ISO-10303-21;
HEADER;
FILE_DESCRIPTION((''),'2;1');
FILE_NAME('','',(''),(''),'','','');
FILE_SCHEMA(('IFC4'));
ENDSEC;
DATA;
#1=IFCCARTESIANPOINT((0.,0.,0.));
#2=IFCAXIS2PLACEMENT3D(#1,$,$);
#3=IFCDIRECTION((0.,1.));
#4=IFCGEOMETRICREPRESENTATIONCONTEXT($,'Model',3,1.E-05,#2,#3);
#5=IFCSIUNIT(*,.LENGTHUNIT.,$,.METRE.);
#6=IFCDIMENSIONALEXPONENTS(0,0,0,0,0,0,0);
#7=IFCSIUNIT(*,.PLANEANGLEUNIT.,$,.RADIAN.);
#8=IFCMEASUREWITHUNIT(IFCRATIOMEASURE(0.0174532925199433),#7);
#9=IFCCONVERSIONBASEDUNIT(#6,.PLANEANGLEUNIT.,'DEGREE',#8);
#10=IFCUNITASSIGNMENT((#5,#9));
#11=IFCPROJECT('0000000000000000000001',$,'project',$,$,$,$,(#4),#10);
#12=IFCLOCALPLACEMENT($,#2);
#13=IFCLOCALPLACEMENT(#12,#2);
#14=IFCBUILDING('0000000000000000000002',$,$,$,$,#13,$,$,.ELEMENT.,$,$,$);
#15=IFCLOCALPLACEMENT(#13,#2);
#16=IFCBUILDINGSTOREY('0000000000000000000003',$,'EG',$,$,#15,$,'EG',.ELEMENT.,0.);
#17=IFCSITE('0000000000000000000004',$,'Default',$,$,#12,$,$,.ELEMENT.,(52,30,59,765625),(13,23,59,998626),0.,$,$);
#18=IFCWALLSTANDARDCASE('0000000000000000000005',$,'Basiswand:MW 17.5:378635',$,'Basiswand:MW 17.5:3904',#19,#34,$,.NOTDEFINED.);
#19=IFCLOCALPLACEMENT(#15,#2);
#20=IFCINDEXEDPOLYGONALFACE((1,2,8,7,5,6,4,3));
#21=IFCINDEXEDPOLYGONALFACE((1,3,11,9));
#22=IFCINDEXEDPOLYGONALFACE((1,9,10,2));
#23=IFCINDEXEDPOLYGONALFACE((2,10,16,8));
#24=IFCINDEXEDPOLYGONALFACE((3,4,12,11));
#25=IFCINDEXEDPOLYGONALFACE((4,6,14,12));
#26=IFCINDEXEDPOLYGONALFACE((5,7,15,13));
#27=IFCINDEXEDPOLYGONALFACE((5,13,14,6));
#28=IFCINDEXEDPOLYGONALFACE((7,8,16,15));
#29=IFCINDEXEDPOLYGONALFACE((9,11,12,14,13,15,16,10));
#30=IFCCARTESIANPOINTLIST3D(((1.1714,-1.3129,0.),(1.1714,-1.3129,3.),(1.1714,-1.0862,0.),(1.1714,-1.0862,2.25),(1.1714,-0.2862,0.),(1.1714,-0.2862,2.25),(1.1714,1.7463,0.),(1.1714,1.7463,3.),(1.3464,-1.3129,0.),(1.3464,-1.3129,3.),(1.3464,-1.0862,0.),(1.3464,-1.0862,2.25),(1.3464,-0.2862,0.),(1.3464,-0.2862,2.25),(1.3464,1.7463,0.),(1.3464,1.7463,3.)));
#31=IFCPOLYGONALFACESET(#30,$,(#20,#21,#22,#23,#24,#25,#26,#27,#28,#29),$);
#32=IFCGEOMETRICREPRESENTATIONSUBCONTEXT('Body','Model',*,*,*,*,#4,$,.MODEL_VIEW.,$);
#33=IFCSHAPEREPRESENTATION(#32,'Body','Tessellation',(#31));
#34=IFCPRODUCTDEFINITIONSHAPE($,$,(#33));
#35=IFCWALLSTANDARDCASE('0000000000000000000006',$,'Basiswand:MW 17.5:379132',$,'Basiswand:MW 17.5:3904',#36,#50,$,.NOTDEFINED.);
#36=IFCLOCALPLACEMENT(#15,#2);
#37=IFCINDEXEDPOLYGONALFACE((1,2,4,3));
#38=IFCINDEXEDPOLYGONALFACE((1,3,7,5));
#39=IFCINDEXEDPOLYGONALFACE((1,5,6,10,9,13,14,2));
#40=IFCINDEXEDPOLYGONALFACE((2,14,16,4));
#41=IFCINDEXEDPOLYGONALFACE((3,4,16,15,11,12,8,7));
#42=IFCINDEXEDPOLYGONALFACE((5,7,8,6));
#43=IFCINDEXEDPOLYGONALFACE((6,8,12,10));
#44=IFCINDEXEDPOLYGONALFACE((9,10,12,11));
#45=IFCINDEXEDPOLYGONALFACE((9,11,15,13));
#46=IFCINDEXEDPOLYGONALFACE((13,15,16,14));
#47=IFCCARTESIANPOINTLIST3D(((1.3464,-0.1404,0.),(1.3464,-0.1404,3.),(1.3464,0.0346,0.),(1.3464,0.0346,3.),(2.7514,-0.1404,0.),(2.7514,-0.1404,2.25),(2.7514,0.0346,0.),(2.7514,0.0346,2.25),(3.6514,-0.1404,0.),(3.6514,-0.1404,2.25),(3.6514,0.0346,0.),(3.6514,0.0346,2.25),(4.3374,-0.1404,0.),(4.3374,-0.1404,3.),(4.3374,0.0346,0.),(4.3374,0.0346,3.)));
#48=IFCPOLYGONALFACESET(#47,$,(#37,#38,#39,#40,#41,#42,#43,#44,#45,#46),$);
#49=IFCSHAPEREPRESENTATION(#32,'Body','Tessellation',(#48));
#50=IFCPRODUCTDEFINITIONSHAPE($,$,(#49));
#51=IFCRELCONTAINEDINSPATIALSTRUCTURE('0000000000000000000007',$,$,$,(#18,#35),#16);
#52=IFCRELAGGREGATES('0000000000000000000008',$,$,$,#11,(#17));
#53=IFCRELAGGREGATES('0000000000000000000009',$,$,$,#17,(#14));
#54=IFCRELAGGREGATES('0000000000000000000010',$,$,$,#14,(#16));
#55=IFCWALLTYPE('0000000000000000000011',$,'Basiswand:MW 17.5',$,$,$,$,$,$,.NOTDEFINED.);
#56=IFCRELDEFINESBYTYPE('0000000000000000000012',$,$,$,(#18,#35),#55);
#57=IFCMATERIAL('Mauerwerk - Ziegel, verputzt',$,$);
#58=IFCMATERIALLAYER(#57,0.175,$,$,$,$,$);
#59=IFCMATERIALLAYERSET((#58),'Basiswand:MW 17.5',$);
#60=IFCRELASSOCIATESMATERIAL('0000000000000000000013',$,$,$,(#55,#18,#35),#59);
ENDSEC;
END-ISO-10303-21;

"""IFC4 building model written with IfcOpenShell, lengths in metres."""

from ifc_helpers import new_model, entity, si_unit, converted_unit, direction, frame, frame_2d, origin, place, context, subcontext, project, spatial, rectangle, extrude, material, layer, layer_set, layer_usage, type_object, element, save


model = new_model("IFC4")

# Units and contexts
model_context = context("Model", 3, precision=1e-05, world=origin(), true_north=direction((0.0, 1.0)))
body_context = subcontext(model_context, "Body", "Model", "MODEL_VIEW")
ifc_project = project(units=[si_unit("LENGTHUNIT", "METRE"), converted_unit("PLANEANGLEUNIT", "DEGREE", entity("IfcRatioMeasure", 0.0174532925199433), si_unit("PLANEANGLEUNIT", "RADIAN"), dimensions=[0, 0, 0, 0, 0, 0, 0])], contexts=[model_context])

# Site, building, storey
site_placement = place(None, origin())
site = spatial("IfcSite", under=ifc_project, at=site_placement, Name="Default", CompositionType="ELEMENT", RefLatitude=(52, 30, 59, 765625), RefLongitude=(13, 23, 59, 998626), RefElevation=0.0)
building_placement = place(site_placement, origin())
building = spatial("IfcBuilding", under=site, at=building_placement, CompositionType="ELEMENT")
storey_placement = place(building_placement, origin())
storey = spatial("IfcBuildingStorey", under=building, at=storey_placement, Name="EG", LongName="EG", CompositionType="ELEMENT", Elevation=0.0)

# Shared definitions
ifc_material = material(Name="Mauerwerk - Ziegel, verputzt")

# Walls, openings
ifc_layer_1 = layer(ifc_material, 0.175)
ifc_layer_set_1 = layer_set([ifc_layer_1], Name="Basiswand:MW 17.5")
ifc_layer_usage_1 = layer_usage(ifc_layer_set_1, "AXIS2", "POSITIVE", -0.0875)
wall_type_1 = type_object("IfcWallType", Name="Basiswand:MW 17.5", PredefinedType="NOTDEFINED", material=ifc_layer_set_1)
wall_1_placement = place(storey_placement, frame((1.2589, 1.7463, 0.0), z_axis=(0.0, 0.0, 1.0), x_axis=(0.0, -1.0, 0.0)))
wall_1 = element("IfcWallStandardCase", 1, at=wall_1_placement, inside=storey, type_object=wall_type_1, material=ifc_layer_usage_1, Name="Basiswand:MW 17.5:378635", ObjectType="Basiswand:MW 17.5:3904", PredefinedType="NOTDEFINED", context=body_context, shape_type="SweptSolid", body=[
    extrude(rectangle(XDim=3.0592, YDim=0.175, at=frame_2d((1.5296, 0.0), x_axis=(-1.0, 0.0))), origin(), (0.0, 0.0, 1.0), 3.0),
])
opening_1_placement = place(wall_1_placement, frame((2.8325, 0.0875, 0.0)))
element("IfcOpeningElement", 2, at=opening_1_placement, cuts=wall_1, ObjectType="Opening", PredefinedType="OPENING", context=body_context, shape_type="SweptSolid", body=[
    extrude(rectangle(XDim=2.25, YDim=0.8, at=frame_2d((1.125, 0.4), x_axis=(1.0, 0.0))), frame((0.0, 0.0, 0.0), z_axis=(0.0, -1.0, 0.0), x_axis=(0.0, 0.0, 1.0)), (0.0, 0.0, 1.0), 0.175),
])
ifc_layer_usage_2 = layer_usage(ifc_layer_set_1, "AXIS2", "NEGATIVE", 0.0875)
wall_2_placement = place(storey_placement, frame((1.3464, -0.0529, 0.0)))
wall_2 = element("IfcWallStandardCase", 3, at=wall_2_placement, inside=storey, type_object=wall_type_1, material=ifc_layer_usage_2, Name="Basiswand:MW 17.5:379132", ObjectType="Basiswand:MW 17.5:3904", PredefinedType="NOTDEFINED", context=body_context, shape_type="SweptSolid", body=[
    extrude(rectangle(XDim=2.991, YDim=0.175, at=frame_2d((1.4955, 0.0), x_axis=(-1.0, 0.0))), origin(), (0.0, 0.0, 1.0), 3.0),
])
opening_2_placement = place(wall_2_placement, frame((1.405, -0.0875, 0.0)))
element("IfcOpeningElement", 4, at=opening_2_placement, cuts=wall_2, ObjectType="Opening", PredefinedType="OPENING", context=body_context, shape_type="SweptSolid", body=[
    extrude(rectangle(XDim=2.25, YDim=0.9, at=frame_2d((1.125, 0.45), x_axis=(1.0, 0.0))), frame((0.0, 0.0, 0.0), z_axis=(0.0, 1.0, 0.0), x_axis=(0.0, 0.0, 1.0)), (0.0, 0.0, 1.0), 0.175),
])

save(model, "model.ifc")
